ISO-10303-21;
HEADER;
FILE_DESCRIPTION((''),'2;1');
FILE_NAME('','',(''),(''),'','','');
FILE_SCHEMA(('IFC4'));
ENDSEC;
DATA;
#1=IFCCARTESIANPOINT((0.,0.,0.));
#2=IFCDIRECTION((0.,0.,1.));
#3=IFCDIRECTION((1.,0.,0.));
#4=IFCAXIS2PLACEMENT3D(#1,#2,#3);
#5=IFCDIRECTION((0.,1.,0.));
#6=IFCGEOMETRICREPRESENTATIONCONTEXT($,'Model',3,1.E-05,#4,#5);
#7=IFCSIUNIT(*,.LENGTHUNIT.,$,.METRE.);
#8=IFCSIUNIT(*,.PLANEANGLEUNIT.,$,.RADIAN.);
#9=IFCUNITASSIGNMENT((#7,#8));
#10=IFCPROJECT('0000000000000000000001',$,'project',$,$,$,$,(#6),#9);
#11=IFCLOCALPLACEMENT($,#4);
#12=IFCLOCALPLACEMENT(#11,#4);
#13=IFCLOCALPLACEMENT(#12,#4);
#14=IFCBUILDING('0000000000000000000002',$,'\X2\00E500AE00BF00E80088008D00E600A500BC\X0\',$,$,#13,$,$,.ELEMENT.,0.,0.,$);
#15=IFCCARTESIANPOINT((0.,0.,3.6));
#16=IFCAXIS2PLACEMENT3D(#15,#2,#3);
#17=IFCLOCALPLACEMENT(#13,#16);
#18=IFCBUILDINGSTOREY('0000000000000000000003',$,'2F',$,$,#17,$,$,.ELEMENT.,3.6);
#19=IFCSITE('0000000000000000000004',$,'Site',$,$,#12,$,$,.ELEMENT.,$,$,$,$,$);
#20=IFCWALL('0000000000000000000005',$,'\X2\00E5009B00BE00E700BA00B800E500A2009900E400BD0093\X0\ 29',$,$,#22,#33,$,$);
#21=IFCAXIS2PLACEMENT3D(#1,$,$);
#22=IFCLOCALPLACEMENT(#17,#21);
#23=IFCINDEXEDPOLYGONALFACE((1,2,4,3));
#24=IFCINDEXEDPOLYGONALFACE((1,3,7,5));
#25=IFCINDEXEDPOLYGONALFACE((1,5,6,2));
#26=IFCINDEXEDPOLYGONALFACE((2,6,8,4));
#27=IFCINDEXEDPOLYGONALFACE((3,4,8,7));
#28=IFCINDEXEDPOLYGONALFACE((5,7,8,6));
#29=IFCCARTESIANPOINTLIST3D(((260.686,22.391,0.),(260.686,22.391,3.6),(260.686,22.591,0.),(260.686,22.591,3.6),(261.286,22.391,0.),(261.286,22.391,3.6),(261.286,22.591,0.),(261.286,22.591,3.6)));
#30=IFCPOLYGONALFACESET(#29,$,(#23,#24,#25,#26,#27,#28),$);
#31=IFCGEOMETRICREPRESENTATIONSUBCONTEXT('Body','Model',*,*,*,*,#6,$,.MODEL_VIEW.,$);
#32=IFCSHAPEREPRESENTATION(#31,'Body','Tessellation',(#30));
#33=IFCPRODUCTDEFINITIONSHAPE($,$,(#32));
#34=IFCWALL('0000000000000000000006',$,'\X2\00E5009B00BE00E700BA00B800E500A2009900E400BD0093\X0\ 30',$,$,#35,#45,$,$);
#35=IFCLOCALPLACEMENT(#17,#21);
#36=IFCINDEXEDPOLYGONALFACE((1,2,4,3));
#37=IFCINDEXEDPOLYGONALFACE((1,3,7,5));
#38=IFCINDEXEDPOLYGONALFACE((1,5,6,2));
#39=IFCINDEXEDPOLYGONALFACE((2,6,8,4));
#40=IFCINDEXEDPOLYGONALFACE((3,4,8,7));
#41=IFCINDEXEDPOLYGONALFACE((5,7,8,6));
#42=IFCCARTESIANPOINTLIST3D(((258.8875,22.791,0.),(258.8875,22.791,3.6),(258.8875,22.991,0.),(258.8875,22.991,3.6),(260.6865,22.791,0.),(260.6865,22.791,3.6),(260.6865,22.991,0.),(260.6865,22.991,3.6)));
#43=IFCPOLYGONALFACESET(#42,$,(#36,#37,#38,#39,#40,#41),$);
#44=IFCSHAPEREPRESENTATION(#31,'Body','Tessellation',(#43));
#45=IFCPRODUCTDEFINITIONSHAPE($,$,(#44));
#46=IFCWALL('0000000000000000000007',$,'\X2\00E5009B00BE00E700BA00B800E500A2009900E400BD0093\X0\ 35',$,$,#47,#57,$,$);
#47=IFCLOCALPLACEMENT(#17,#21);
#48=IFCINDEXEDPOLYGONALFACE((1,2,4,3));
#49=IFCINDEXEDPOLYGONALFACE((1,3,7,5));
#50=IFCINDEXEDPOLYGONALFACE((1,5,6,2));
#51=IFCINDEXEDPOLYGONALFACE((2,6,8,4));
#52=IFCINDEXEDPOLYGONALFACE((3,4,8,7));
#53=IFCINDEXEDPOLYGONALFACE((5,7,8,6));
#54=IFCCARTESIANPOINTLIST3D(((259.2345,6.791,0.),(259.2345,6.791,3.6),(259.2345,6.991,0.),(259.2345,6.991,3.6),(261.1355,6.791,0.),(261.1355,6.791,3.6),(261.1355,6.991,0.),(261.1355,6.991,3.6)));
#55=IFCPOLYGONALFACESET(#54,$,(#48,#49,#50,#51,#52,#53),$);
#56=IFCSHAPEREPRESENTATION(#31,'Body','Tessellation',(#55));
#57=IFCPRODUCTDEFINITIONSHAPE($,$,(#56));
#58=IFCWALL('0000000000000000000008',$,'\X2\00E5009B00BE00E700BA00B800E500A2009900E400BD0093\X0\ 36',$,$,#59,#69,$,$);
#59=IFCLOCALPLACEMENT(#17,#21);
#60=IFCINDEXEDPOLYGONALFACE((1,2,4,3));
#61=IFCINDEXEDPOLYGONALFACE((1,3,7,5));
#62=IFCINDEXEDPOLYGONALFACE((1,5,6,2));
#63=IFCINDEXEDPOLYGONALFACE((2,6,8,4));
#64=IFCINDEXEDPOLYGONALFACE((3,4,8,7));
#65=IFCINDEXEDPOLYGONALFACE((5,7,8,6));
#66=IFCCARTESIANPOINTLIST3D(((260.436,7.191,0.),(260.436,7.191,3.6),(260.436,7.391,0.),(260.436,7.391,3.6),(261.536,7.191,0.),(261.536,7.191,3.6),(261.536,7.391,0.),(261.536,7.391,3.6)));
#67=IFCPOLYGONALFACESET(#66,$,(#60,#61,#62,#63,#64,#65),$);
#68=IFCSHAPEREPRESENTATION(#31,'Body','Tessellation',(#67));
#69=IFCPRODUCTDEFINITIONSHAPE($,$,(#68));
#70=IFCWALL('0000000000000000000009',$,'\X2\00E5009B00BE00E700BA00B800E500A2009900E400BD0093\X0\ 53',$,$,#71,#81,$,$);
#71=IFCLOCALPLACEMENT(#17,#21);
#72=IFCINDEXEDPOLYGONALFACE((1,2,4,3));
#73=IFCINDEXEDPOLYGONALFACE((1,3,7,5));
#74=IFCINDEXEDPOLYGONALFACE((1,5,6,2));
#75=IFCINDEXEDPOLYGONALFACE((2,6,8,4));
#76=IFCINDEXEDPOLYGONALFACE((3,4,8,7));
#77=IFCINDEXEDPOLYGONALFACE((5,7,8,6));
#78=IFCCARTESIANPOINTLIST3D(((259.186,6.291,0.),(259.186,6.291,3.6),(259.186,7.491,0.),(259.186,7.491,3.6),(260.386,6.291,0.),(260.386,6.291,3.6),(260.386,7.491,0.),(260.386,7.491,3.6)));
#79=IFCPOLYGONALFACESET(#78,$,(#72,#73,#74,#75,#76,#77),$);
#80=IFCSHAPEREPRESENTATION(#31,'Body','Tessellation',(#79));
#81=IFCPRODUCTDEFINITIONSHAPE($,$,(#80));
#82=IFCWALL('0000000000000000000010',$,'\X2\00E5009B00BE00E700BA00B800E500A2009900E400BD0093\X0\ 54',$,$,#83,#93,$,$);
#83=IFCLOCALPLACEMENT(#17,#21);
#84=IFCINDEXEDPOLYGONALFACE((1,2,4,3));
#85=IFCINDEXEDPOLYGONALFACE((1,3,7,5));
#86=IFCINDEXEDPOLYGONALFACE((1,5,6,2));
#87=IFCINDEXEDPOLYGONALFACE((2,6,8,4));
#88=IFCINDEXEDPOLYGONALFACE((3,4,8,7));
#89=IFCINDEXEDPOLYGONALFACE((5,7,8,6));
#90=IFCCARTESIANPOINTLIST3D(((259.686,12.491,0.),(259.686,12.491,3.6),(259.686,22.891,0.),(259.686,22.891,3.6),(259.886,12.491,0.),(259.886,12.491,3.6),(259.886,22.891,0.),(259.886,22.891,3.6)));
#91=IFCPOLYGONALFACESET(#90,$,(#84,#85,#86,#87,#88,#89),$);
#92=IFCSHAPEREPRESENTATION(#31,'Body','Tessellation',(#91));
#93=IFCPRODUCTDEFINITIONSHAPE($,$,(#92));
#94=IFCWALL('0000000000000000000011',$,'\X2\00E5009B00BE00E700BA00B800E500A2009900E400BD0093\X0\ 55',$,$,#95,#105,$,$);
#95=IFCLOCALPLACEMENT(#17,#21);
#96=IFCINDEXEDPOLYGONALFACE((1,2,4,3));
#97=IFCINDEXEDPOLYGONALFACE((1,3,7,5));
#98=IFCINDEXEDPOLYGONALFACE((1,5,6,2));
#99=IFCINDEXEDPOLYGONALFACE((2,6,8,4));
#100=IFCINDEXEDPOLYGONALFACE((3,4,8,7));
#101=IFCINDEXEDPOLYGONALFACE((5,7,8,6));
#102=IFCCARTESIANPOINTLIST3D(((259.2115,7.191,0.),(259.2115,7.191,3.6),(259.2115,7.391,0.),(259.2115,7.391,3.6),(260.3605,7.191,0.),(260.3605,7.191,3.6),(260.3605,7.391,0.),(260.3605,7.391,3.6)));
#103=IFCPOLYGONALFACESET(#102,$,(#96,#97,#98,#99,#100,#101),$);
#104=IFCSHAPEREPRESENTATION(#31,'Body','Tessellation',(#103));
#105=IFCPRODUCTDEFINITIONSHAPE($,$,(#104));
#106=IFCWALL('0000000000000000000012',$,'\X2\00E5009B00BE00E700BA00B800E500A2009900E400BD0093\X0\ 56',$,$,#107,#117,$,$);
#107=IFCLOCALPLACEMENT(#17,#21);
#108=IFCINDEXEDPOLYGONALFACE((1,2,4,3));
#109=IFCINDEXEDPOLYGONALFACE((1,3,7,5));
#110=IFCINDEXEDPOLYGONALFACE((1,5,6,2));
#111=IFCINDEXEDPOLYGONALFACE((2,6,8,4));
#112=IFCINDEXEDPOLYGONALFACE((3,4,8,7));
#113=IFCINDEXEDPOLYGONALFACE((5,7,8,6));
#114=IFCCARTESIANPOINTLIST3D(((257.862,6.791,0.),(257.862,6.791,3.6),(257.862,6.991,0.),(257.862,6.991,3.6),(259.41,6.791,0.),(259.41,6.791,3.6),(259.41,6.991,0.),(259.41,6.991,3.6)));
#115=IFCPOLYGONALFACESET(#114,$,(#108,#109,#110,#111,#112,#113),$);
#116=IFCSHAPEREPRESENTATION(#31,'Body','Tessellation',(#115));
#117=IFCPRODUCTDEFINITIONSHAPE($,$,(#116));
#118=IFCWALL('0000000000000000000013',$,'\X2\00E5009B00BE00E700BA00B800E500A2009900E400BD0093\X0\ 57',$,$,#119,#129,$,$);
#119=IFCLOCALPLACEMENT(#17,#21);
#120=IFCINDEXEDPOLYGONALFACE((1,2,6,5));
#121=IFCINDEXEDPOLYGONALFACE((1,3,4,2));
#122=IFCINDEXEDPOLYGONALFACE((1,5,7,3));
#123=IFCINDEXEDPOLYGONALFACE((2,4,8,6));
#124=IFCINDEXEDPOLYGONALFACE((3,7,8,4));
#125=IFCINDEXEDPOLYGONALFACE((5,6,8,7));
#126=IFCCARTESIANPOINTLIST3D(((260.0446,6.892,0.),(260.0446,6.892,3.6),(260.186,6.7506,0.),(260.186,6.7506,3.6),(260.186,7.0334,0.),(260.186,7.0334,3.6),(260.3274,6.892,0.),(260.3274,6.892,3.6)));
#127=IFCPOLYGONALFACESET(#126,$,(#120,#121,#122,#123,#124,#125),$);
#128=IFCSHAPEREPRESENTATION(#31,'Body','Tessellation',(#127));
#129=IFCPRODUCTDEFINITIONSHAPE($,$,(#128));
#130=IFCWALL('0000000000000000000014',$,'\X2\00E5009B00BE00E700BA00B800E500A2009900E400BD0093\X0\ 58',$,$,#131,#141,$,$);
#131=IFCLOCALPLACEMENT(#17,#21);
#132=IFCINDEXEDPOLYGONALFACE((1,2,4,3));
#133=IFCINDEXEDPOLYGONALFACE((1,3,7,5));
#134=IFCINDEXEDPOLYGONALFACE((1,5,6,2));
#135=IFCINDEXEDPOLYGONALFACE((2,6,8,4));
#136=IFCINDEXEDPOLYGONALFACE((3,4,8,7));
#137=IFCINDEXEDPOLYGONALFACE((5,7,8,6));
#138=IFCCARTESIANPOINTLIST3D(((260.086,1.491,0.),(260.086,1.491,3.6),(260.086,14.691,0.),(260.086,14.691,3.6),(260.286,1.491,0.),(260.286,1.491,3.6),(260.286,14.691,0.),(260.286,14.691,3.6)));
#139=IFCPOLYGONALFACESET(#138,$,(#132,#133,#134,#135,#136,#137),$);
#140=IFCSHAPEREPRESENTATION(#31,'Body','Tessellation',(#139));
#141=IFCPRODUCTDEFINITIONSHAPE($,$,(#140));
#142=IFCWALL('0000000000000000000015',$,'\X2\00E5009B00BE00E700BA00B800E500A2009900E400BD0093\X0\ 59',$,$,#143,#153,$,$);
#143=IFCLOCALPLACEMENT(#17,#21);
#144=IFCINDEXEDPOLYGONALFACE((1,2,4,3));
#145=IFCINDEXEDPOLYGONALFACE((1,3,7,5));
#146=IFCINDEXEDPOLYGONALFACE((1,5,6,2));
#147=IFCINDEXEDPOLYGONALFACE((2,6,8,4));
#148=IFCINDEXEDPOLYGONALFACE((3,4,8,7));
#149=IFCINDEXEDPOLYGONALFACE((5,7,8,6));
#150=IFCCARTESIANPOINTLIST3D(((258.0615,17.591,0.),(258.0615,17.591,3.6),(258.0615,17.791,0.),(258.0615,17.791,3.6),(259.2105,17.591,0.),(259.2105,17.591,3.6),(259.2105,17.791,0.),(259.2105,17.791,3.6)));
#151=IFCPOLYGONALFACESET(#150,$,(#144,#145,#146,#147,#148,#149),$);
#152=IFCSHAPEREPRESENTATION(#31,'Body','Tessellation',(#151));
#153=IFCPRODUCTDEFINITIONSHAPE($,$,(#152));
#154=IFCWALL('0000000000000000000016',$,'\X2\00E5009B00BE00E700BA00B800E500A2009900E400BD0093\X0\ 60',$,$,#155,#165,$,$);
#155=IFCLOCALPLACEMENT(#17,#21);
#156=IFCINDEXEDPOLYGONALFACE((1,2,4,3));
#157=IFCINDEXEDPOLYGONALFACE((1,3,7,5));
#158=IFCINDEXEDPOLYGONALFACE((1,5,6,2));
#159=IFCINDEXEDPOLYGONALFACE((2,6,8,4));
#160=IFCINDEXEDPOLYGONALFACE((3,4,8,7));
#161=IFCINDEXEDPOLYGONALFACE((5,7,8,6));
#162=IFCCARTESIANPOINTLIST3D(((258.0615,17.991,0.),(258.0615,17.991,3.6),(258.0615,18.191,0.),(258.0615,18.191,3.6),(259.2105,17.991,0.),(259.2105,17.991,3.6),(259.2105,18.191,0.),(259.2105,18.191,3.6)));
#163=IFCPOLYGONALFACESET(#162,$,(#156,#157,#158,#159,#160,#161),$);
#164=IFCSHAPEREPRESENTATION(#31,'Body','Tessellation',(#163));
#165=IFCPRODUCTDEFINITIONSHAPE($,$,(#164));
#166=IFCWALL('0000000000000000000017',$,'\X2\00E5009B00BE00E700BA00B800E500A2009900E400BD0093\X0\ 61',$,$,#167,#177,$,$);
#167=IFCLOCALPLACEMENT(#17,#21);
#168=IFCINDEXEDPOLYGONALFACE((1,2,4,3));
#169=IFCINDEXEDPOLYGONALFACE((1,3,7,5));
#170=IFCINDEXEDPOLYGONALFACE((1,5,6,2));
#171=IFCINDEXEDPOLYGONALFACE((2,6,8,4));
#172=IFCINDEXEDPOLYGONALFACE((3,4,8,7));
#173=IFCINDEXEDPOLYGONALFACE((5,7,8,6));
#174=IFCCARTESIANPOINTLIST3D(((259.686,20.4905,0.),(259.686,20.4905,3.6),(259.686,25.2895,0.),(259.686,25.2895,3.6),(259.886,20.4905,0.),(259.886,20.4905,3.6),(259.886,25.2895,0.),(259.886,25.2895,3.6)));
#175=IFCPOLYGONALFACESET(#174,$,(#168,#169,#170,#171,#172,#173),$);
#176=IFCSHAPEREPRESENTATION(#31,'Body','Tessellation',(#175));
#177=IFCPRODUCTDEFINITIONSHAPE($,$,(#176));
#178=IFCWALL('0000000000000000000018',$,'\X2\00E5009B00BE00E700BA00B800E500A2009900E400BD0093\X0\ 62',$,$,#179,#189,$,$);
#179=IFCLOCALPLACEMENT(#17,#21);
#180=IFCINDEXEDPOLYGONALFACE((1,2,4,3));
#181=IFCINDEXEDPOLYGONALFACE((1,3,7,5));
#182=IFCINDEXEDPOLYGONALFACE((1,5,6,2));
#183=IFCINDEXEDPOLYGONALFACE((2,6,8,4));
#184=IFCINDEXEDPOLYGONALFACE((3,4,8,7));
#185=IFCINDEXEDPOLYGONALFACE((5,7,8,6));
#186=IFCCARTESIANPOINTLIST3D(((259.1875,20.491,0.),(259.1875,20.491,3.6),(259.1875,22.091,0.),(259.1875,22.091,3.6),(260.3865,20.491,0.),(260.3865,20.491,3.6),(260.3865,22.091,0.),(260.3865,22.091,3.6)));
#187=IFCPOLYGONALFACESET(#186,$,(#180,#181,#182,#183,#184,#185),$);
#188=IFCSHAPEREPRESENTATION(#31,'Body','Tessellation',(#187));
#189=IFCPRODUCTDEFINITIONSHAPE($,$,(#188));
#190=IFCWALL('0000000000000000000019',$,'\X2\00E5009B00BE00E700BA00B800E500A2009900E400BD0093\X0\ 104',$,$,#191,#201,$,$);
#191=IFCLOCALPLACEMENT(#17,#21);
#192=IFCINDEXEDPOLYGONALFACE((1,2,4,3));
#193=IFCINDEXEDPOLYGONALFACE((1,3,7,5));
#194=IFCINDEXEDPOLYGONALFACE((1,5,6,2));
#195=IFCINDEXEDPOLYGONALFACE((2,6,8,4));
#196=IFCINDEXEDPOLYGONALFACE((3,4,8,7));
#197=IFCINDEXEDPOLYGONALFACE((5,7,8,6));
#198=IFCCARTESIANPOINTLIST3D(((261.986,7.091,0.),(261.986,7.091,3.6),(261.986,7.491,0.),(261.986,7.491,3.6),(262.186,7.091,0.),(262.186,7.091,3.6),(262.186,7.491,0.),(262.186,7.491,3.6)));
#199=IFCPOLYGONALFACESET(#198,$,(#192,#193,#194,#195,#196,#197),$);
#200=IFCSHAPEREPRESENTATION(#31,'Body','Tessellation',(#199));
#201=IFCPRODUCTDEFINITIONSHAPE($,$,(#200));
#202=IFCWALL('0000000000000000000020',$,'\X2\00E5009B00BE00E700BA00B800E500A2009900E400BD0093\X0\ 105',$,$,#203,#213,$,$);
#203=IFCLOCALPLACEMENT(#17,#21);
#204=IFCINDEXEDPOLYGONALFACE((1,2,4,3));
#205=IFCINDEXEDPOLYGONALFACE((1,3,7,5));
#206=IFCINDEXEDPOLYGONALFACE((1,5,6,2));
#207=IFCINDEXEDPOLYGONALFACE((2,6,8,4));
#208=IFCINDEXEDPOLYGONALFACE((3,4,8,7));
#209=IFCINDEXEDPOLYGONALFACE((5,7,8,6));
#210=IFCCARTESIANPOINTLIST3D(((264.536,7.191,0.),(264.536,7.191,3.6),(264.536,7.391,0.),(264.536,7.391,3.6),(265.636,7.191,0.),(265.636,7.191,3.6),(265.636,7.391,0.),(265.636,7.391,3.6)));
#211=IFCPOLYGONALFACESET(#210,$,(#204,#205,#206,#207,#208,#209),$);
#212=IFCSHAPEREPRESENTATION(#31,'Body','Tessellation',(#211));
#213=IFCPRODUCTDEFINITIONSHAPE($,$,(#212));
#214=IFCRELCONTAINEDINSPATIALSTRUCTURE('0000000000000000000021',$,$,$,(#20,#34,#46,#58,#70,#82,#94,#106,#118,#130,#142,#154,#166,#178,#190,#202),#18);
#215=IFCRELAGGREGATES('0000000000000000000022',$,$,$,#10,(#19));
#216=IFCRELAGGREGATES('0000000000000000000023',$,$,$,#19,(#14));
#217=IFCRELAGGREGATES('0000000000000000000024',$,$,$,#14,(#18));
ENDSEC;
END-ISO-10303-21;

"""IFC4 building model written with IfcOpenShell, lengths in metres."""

from ifc_helpers import new_model, si_unit, direction, frame, frame_2d, origin_with_axes, place, context, subcontext, project, spatial, rectangle, extrude, element, save


model = new_model("IFC4")

# Units and contexts
model_context = context("Model", 3, precision=1e-05, world=origin_with_axes(), true_north=direction((0.0, 1.0, 0.0)))
body_context = subcontext(model_context, "Body", "Model", "MODEL_VIEW")
ifc_project = project(units=[si_unit("LENGTHUNIT", "METRE"), si_unit("PLANEANGLEUNIT", "RADIAN")], contexts=[model_context])

# Site, building, storey
placement = place(None, origin_with_axes())
site_placement = place(placement, origin_with_axes())
site = spatial("IfcSite", under=ifc_project, at=site_placement, Name="Site", CompositionType="ELEMENT")
building_placement = place(site_placement, origin_with_axes())
building = spatial("IfcBuilding", under=site, at=building_placement, Name="å®¿è\u0088\u008dæ¥¼", CompositionType="ELEMENT", ElevationOfRefHeight=0.0, ElevationOfTerrain=0.0)
storey_placement = place(building_placement, frame((0.0, 0.0, 3.6), z_axis=(0.0, 0.0, 1.0), x_axis=(1.0, 0.0, 0.0)))
storey = spatial("IfcBuildingStorey", under=building, at=storey_placement, Name="2F", CompositionType="ELEMENT", Elevation=3.6)

# Walls
wall_1_placement = place(storey_placement, frame((260.986, 22.491, 0.0), z_axis=(0.0, 0.0, 1.0), x_axis=(1.0, 0.0, 0.0)))
element("IfcWall", 1, at=wall_1_placement, inside=storey, Name="å\u009b¾çº¸å¢\u0099ä½\u0093 29", context=body_context, shape_type="SweptSolid", body=[
    extrude(rectangle(XDim=0.6, YDim=0.2, at=frame_2d((0.0, 0.0), x_axis=(1.0, 0.0, 0.0))), frame((0.0, 0.0, 0.0), z_axis=(0.0, 0.0, 1.0)), (0.0, 0.0, 1.0), 3.6),
])
wall_2_placement = place(storey_placement, frame((259.787, 22.891, 0.0), z_axis=(0.0, 0.0, 1.0), x_axis=(1.0, 0.0, 0.0)))
element("IfcWall", 2, at=wall_2_placement, inside=storey, Name="å\u009b¾çº¸å¢\u0099ä½\u0093 30", context=body_context, shape_type="SweptSolid", body=[
    extrude(rectangle(XDim=1.799, YDim=0.2, at=frame_2d((0.0, 0.0), x_axis=(1.0, 0.0, 0.0))), frame((0.0, 0.0, 0.0), z_axis=(0.0, 0.0, 1.0)), (0.0, 0.0, 1.0), 3.6),
])
wall_3_placement = place(storey_placement, frame((260.185, 6.891, 0.0), z_axis=(0.0, 0.0, 1.0), x_axis=(1.0, 0.0, 0.0)))
element("IfcWall", 3, at=wall_3_placement, inside=storey, Name="å\u009b¾çº¸å¢\u0099ä½\u0093 35", context=body_context, shape_type="SweptSolid", body=[
    extrude(rectangle(XDim=1.901, YDim=0.2, at=frame_2d((0.0, 0.0), x_axis=(1.0, 0.0, 0.0))), frame((0.0, 0.0, 0.0), z_axis=(0.0, 0.0, 1.0)), (0.0, 0.0, 1.0), 3.6),
])
wall_4_placement = place(storey_placement, frame((260.986, 7.291, 0.0), z_axis=(0.0, 0.0, 1.0), x_axis=(1.0, 0.0, 0.0)))
element("IfcWall", 4, at=wall_4_placement, inside=storey, Name="å\u009b¾çº¸å¢\u0099ä½\u0093 36", context=body_context, shape_type="SweptSolid", body=[
    extrude(rectangle(XDim=1.1, YDim=0.2, at=frame_2d((0.0, 0.0), x_axis=(1.0, 0.0, 0.0))), frame((0.0, 0.0, 0.0), z_axis=(0.0, 0.0, 1.0)), (0.0, 0.0, 1.0), 3.6),
])
wall_5_placement = place(storey_placement, frame((259.786, 6.891, 0.0), z_axis=(0.0, 0.0, 1.0), x_axis=(1.0, 0.0, 0.0)))
element("IfcWall", 5, at=wall_5_placement, inside=storey, Name="å\u009b¾çº¸å¢\u0099ä½\u0093 53", context=body_context, shape_type="SweptSolid", body=[
    extrude(rectangle(XDim=1.2, YDim=1.2, at=frame_2d((0.0, 0.0), x_axis=(1.0, 0.0, 0.0))), frame((0.0, 0.0, 0.0), z_axis=(0.0, 0.0, 1.0)), (0.0, 0.0, 1.0), 3.6),
])
wall_6_placement = place(storey_placement, frame((259.786, 17.691, 0.0), z_axis=(0.0, 0.0, 1.0), x_axis=(0.0, -1.0, 0.0)))
element("IfcWall", 6, at=wall_6_placement, inside=storey, Name="å\u009b¾çº¸å¢\u0099ä½\u0093 54", context=body_context, shape_type="SweptSolid", body=[
    extrude(rectangle(XDim=10.4, YDim=0.2, at=frame_2d((0.0, 0.0), x_axis=(1.0, 0.0, 0.0))), frame((0.0, 0.0, 0.0), z_axis=(0.0, 0.0, 1.0)), (0.0, 0.0, 1.0), 3.6),
])
wall_7_placement = place(storey_placement, frame((259.786, 7.291, 0.0), z_axis=(0.0, 0.0, 1.0), x_axis=(-1.0, 0.0, 0.0)))
element("IfcWall", 7, at=wall_7_placement, inside=storey, Name="å\u009b¾çº¸å¢\u0099ä½\u0093 55", context=body_context, shape_type="SweptSolid", body=[
    extrude(rectangle(XDim=1.149, YDim=0.2, at=frame_2d((0.0, 0.0), x_axis=(1.0, 0.0, 0.0))), frame((0.0, 0.0, 0.0), z_axis=(0.0, 0.0, 1.0)), (0.0, 0.0, 1.0), 3.6),
])
wall_8_placement = place(storey_placement, frame((258.636, 6.891, 0.0), z_axis=(0.0, 0.0, 1.0), x_axis=(1.0, 0.0, 0.0)))
element("IfcWall", 8, at=wall_8_placement, inside=storey, Name="å\u009b¾çº¸å¢\u0099ä½\u0093 56", context=body_context, shape_type="SweptSolid", body=[
    extrude(rectangle(XDim=1.548, YDim=0.2, at=frame_2d((0.0, 0.0), x_axis=(1.0, 0.0, 0.0))), frame((0.0, 0.0, 0.0), z_axis=(0.0, 0.0, 1.0)), (0.0, 0.0, 1.0), 3.6),
])
wall_9_placement = place(storey_placement, frame((260.186, 6.892, 0.0), z_axis=(0.0, 0.0, 1.0), x_axis=(-0.707107, -0.707107, 0.0)))
element("IfcWall", 9, at=wall_9_placement, inside=storey, Name="å\u009b¾çº¸å¢\u0099ä½\u0093 57", context=body_context, shape_type="SweptSolid", body=[
    extrude(rectangle(XDim=0.2, YDim=0.2, at=frame_2d((0.0, 0.0), x_axis=(1.0, 0.0, 0.0))), frame((0.0, 0.0, 0.0), z_axis=(0.0, 0.0, 1.0)), (0.0, 0.0, 1.0), 3.6),
])
wall_10_placement = place(storey_placement, frame((260.186, 8.091, 0.0), z_axis=(0.0, 0.0, 1.0), x_axis=(0.0, 1.0, 0.0)))
element("IfcWall", 10, at=wall_10_placement, inside=storey, Name="å\u009b¾çº¸å¢\u0099ä½\u0093 58", context=body_context, shape_type="SweptSolid", body=[
    extrude(rectangle(XDim=13.2, YDim=0.2, at=frame_2d((0.0, 0.0), x_axis=(1.0, 0.0, 0.0))), frame((0.0, 0.0, 0.0), z_axis=(0.0, 0.0, 1.0)), (0.0, 0.0, 1.0), 3.6),
])
for number, where, z_axis, x_axis, name in (
    (11, (258.636, 17.691, 0.0), (0.0, 0.0, 1.0), (1.0, 0.0, 0.0), "å\u009b¾çº¸å¢\u0099ä½\u0093 59"),
    (12, (258.636, 18.091, 0.0), (0.0, 0.0, 1.0), (1.0, 0.0, 0.0), "å\u009b¾çº¸å¢\u0099ä½\u0093 60"),
):
    element("IfcWall", number, at=place(storey_placement, frame(where, z_axis=z_axis, x_axis=x_axis)), inside=storey, Name=name, context=body_context, shape_type="SweptSolid", body=[
        extrude(rectangle(XDim=1.149, YDim=0.2, at=frame_2d((0.0, 0.0), x_axis=(1.0, 0.0, 0.0))), frame((0.0, 0.0, 0.0), z_axis=(0.0, 0.0, 1.0)), (0.0, 0.0, 1.0), 3.6),
    ])
wall_11_placement = place(storey_placement, frame((259.786, 22.89, 0.0), z_axis=(0.0, 0.0, 1.0), x_axis=(0.0, -1.0, 0.0)))
element("IfcWall", 13, at=wall_11_placement, inside=storey, Name="å\u009b¾çº¸å¢\u0099ä½\u0093 61", context=body_context, shape_type="SweptSolid", body=[
    extrude(rectangle(XDim=4.799, YDim=0.2, at=frame_2d((0.0, 0.0), x_axis=(1.0, 0.0, 0.0))), frame((0.0, 0.0, 0.0), z_axis=(0.0, 0.0, 1.0)), (0.0, 0.0, 1.0), 3.6),
])
wall_12_placement = place(storey_placement, frame((259.787, 21.291, 0.0), z_axis=(0.0, 0.0, 1.0), x_axis=(1.0, 0.0, 0.0)))
element("IfcWall", 14, at=wall_12_placement, inside=storey, Name="å\u009b¾çº¸å¢\u0099ä½\u0093 62", context=body_context, shape_type="SweptSolid", body=[
    extrude(rectangle(XDim=1.199, YDim=1.6, at=frame_2d((0.0, 0.0), x_axis=(1.0, 0.0, 0.0))), frame((0.0, 0.0, 0.0), z_axis=(0.0, 0.0, 1.0)), (0.0, 0.0, 1.0), 3.6),
])
wall_13_placement = place(storey_placement, frame((262.086, 7.291, 0.0), z_axis=(0.0, 0.0, 1.0), x_axis=(0.0, -1.0, 0.0)))
element("IfcWall", 15, at=wall_13_placement, inside=storey, Name="å\u009b¾çº¸å¢\u0099ä½\u0093 104", context=body_context, shape_type="SweptSolid", body=[
    extrude(rectangle(XDim=0.4, YDim=0.2, at=frame_2d((0.0, 0.0), x_axis=(1.0, 0.0, 0.0))), frame((0.0, 0.0, 0.0), z_axis=(0.0, 0.0, 1.0)), (0.0, 0.0, 1.0), 3.6),
])
wall_14_placement = place(storey_placement, frame((265.086, 7.291, 0.0), z_axis=(0.0, 0.0, 1.0), x_axis=(1.0, 0.0, 0.0)))
element("IfcWall", 16, at=wall_14_placement, inside=storey, Name="å\u009b¾çº¸å¢\u0099ä½\u0093 105", context=body_context, shape_type="SweptSolid", body=[
    extrude(rectangle(XDim=1.1, YDim=0.2, at=frame_2d((0.0, 0.0), x_axis=(1.0, 0.0, 0.0))), frame((0.0, 0.0, 0.0), z_axis=(0.0, 0.0, 1.0)), (0.0, 0.0, 1.0), 3.6),
])

save(model, "model.ifc")
